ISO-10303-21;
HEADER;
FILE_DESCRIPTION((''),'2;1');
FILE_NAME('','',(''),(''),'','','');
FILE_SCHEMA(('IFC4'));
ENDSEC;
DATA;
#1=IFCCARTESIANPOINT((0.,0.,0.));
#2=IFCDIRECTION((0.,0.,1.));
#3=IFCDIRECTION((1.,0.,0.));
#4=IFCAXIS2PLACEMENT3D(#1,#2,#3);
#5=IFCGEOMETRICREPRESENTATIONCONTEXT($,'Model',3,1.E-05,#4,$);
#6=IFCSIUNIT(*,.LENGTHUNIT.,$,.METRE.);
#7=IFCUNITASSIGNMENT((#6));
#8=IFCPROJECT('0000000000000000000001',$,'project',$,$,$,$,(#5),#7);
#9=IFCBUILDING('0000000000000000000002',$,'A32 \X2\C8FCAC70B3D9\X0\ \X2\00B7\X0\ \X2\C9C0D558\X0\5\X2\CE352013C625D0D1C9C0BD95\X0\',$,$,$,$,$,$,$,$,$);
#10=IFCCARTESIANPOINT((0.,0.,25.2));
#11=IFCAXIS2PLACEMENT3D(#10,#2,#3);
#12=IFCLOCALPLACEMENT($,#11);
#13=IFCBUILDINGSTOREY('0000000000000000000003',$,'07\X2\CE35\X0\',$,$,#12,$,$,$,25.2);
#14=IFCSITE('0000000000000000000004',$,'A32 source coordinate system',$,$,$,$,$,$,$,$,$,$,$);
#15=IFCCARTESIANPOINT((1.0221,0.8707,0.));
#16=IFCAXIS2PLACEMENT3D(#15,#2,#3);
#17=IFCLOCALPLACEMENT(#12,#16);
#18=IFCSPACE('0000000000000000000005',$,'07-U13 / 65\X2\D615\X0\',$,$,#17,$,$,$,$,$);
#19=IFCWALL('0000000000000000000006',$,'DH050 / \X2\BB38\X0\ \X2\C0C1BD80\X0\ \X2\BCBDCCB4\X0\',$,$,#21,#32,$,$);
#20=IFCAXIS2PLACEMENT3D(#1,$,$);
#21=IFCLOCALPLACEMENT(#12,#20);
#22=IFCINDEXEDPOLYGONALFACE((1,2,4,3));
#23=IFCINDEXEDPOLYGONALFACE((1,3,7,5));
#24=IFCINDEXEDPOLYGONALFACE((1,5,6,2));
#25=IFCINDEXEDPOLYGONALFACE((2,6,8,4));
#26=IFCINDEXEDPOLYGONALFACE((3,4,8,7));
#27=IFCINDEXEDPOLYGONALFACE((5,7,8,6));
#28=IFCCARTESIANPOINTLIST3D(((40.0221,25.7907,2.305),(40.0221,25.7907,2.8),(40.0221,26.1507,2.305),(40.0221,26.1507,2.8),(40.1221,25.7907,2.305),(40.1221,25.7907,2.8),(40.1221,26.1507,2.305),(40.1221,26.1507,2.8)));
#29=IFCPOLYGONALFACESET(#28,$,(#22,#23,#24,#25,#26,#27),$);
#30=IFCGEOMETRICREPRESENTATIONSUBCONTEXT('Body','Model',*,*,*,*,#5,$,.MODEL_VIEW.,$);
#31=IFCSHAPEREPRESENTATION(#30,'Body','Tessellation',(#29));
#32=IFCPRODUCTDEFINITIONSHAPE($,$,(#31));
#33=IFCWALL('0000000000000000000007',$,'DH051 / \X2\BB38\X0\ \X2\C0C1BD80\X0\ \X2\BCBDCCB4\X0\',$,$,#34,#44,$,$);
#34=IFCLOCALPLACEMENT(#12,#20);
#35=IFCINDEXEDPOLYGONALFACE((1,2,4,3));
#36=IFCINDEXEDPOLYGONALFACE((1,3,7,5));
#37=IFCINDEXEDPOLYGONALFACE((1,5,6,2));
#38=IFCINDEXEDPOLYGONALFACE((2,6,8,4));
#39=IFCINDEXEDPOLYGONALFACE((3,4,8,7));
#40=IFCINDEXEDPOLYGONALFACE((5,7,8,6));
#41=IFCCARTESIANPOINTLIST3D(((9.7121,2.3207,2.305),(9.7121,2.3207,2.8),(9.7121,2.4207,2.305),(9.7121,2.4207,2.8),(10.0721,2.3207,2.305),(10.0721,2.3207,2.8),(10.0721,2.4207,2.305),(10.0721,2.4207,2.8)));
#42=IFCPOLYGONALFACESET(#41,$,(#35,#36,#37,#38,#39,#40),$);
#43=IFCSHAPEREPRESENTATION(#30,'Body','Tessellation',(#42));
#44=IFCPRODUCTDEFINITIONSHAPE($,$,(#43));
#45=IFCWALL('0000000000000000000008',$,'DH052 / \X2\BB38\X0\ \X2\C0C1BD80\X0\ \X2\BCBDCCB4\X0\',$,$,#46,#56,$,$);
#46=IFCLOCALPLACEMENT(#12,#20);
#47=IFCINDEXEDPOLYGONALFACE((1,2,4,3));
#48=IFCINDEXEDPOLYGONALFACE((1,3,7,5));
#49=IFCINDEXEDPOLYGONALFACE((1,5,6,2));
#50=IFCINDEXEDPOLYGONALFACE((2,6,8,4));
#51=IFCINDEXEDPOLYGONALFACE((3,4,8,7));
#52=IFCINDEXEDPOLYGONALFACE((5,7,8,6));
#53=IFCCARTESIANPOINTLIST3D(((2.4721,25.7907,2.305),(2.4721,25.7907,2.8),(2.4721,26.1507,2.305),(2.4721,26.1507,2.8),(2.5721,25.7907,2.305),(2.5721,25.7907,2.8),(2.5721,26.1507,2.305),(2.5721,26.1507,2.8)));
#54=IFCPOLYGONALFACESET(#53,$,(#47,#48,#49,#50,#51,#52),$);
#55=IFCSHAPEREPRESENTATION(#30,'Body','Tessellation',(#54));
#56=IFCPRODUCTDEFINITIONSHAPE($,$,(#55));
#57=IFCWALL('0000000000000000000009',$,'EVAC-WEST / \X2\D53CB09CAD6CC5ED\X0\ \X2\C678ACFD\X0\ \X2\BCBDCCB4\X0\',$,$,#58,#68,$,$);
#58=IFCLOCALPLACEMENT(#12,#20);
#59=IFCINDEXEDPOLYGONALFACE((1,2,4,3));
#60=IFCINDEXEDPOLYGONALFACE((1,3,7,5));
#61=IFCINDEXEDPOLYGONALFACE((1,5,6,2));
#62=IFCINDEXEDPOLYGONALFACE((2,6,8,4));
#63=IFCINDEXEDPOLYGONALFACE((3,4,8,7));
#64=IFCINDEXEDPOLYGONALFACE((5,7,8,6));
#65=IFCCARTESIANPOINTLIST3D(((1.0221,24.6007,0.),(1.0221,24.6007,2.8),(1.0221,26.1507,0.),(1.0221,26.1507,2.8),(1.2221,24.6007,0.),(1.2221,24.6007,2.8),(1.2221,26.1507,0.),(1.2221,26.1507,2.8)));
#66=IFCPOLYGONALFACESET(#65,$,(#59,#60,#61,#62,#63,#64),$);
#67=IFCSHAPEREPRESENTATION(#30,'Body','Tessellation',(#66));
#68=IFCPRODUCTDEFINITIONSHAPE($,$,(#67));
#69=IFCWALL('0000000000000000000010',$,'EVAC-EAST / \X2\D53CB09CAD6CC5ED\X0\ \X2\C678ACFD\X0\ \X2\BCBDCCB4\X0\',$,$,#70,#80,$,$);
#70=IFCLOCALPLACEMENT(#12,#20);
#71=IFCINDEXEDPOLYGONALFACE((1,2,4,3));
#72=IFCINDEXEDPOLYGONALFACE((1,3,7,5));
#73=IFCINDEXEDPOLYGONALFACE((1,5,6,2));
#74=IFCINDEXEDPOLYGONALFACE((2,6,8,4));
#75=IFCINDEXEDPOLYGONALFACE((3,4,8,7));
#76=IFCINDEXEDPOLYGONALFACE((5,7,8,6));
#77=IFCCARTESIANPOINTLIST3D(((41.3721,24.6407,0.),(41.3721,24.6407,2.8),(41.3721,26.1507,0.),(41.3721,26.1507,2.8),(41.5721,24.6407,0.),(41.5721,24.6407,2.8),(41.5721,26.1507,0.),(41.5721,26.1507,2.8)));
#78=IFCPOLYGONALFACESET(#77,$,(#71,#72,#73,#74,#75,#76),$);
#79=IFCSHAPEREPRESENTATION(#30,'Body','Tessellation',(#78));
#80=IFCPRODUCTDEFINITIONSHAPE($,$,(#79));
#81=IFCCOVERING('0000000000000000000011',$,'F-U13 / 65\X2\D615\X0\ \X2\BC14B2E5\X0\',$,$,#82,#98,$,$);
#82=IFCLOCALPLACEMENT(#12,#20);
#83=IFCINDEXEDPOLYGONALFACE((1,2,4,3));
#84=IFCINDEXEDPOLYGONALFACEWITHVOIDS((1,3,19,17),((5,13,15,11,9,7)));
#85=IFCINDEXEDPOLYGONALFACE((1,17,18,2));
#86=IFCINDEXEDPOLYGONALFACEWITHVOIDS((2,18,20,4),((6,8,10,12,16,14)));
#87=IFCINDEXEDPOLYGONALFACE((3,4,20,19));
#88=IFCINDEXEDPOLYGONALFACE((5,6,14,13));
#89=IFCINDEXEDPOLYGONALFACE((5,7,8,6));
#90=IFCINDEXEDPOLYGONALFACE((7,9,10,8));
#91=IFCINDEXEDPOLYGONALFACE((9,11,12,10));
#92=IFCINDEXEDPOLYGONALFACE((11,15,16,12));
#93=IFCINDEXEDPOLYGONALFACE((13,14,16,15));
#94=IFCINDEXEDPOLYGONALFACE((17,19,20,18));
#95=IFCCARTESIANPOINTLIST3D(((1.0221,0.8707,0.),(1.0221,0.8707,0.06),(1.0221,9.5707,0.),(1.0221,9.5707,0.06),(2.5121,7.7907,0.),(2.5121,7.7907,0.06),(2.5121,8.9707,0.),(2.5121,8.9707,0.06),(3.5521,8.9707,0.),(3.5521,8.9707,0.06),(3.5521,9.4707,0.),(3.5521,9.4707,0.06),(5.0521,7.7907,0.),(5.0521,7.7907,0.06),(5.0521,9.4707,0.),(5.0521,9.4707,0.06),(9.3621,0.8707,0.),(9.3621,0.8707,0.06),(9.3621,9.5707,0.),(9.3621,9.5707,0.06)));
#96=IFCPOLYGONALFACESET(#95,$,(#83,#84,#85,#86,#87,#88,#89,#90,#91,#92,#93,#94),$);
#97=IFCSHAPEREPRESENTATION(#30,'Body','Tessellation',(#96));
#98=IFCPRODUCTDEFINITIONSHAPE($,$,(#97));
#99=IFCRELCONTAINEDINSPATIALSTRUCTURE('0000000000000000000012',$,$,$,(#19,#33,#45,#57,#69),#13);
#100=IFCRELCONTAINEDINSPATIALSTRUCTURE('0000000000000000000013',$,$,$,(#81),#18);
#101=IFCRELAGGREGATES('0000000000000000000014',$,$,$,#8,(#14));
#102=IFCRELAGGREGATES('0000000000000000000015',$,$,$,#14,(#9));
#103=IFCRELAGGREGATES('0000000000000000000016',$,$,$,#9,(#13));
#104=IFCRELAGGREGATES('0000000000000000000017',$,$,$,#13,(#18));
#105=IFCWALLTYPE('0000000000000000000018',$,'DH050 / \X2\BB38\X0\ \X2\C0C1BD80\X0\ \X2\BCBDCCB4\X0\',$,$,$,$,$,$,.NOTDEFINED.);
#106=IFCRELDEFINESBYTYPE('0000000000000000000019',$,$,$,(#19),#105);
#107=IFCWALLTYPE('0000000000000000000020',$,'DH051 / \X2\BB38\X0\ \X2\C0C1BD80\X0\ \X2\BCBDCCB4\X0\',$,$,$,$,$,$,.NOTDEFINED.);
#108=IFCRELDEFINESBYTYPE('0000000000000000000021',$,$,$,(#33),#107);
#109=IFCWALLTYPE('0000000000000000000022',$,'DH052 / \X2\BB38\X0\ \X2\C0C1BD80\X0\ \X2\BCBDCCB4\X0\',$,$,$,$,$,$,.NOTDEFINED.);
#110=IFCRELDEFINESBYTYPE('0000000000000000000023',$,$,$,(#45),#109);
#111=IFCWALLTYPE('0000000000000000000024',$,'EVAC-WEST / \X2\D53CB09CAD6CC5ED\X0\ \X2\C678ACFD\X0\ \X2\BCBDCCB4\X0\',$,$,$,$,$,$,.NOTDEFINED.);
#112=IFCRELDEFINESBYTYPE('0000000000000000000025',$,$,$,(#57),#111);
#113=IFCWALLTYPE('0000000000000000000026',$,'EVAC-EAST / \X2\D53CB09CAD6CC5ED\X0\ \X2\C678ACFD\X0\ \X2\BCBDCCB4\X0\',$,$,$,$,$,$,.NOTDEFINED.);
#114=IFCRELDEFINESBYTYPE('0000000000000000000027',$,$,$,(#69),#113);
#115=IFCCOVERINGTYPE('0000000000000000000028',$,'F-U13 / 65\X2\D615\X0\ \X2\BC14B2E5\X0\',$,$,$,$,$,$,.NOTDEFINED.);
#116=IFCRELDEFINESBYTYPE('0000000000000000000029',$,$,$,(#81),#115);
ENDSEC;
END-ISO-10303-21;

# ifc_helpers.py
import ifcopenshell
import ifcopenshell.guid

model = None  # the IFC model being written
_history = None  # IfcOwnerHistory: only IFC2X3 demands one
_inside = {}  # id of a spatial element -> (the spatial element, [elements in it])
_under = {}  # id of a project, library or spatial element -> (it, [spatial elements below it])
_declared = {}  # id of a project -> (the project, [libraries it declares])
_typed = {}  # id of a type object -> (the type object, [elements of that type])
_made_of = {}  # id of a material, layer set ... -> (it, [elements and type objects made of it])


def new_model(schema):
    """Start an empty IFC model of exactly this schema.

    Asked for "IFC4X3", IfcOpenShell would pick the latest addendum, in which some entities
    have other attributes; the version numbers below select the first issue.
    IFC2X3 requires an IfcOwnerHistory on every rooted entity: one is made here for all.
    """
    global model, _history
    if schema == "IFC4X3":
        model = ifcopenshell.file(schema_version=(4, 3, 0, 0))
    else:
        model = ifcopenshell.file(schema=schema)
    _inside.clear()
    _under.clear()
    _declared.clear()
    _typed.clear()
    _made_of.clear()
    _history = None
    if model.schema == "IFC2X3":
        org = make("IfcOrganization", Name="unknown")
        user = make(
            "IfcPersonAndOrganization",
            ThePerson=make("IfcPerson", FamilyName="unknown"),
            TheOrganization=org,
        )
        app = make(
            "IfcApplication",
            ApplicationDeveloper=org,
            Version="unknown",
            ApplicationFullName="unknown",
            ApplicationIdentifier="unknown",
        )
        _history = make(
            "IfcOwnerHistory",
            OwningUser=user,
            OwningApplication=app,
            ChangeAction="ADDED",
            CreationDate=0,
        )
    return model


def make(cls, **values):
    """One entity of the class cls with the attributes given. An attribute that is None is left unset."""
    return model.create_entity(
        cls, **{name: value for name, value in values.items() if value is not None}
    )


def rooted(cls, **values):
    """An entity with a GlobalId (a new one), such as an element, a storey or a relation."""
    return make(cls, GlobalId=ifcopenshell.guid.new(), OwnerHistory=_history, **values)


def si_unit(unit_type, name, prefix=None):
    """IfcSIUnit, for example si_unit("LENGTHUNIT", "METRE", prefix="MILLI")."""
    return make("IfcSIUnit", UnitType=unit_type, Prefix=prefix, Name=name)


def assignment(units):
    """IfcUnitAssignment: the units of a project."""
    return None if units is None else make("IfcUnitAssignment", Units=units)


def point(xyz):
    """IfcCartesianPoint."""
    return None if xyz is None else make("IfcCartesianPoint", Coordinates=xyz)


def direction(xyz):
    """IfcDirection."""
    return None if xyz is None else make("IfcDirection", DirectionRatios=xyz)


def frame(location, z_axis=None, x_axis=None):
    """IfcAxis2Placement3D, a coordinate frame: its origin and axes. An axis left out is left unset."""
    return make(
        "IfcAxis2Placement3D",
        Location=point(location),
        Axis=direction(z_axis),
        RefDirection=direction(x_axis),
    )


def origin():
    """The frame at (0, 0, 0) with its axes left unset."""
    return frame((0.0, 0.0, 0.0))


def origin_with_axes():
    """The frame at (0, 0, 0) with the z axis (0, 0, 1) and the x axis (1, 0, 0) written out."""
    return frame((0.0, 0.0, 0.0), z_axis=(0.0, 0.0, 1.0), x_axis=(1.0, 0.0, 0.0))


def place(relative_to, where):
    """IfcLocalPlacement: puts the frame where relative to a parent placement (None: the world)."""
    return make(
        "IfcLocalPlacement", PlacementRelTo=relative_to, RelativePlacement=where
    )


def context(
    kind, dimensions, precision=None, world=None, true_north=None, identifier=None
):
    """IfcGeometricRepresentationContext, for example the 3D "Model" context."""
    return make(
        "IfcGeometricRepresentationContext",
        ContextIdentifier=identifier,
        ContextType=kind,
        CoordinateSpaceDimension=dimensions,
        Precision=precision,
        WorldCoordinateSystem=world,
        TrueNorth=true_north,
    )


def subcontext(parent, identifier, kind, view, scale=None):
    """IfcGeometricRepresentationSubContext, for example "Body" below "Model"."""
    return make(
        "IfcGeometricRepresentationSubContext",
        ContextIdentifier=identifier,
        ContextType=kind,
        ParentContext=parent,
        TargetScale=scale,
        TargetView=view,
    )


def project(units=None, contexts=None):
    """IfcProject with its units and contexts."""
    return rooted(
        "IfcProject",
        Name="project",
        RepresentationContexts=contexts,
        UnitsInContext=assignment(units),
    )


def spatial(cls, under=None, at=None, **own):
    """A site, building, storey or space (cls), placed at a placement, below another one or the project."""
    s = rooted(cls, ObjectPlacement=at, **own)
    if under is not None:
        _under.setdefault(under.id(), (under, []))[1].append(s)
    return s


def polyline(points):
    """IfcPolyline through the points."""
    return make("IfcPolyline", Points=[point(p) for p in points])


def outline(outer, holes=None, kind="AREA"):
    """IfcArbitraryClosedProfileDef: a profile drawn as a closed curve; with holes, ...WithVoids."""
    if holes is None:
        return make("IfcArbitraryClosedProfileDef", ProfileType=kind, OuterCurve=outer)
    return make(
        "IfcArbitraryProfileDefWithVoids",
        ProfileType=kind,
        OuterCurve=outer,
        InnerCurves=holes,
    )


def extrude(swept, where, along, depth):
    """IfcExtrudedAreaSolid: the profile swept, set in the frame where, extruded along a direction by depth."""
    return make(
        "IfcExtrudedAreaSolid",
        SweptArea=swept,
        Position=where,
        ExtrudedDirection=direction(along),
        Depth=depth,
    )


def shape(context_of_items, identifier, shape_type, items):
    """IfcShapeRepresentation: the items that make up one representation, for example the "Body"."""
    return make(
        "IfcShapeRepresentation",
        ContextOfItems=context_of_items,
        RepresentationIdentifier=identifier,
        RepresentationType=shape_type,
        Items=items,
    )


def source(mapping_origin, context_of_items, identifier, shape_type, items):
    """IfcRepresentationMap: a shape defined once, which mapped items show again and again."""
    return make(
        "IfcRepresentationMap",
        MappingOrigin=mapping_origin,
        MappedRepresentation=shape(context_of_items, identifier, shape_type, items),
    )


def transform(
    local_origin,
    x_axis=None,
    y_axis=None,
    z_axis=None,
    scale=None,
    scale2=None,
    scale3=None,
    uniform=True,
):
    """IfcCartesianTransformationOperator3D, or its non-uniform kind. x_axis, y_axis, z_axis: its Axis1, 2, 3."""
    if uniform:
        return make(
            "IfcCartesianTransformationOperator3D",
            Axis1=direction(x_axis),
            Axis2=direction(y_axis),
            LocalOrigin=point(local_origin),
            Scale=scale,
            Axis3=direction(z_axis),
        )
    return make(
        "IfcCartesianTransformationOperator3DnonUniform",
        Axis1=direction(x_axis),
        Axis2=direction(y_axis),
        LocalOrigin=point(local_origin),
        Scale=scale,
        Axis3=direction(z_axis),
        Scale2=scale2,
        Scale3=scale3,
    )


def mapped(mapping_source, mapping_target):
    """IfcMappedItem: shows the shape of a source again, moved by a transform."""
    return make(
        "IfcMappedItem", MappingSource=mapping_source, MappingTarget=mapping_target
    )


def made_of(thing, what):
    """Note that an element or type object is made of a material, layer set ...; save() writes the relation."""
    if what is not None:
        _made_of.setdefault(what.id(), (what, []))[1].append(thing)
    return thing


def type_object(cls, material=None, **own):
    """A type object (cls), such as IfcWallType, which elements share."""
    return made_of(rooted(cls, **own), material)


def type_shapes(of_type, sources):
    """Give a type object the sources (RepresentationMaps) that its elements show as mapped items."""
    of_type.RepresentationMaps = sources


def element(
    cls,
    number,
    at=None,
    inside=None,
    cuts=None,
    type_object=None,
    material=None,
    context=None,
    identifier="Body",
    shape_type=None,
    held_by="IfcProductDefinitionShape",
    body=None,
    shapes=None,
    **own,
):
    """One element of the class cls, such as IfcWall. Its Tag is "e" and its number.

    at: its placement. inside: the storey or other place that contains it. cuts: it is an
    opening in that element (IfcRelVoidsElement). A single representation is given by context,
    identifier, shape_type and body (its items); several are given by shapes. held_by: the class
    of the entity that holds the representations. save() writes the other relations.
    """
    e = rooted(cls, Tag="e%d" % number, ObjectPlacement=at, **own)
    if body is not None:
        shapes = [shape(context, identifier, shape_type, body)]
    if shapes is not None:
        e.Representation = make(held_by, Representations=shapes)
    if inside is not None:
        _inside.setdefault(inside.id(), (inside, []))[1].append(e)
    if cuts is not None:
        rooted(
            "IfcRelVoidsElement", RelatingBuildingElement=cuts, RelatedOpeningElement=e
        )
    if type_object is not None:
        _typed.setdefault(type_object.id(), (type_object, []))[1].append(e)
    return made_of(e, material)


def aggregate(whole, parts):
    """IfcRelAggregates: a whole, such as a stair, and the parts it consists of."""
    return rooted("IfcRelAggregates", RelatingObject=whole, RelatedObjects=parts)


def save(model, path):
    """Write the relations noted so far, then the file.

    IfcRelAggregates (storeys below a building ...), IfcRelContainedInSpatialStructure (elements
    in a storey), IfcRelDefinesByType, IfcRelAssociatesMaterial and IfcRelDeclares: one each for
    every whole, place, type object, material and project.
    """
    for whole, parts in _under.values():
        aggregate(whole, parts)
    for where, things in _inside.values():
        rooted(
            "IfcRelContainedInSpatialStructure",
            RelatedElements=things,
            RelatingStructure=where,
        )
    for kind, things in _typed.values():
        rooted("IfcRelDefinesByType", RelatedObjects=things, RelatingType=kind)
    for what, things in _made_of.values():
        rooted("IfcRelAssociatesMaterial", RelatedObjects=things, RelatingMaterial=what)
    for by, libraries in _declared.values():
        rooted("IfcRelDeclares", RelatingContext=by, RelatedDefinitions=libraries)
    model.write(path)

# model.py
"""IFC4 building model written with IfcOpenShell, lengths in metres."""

from ifc_helpers import new_model, si_unit, frame, origin, origin_with_axes, place, context, subcontext, project, spatial, polyline, outline, extrude, source, transform, mapped, type_object, type_shapes, element, save


model = new_model("IFC4")

# Units and contexts
model_context = context("Model", 3, precision=1e-05, world=origin_with_axes())
body_context = subcontext(model_context, "Body", "Model", "MODEL_VIEW")
ifc_project = project(units=[si_unit("LENGTHUNIT", "METRE")], contexts=[model_context])

# Site, building, storey
site = spatial("IfcSite", under=ifc_project, Name="A32 source coordinate system")
building = spatial("IfcBuilding", under=site, Name="A32 주거동 · 지하5층–옥탑지붕")
storey_placement = place(None, frame((0.0, 0.0, 25.2), z_axis=(0.0, 0.0, 1.0), x_axis=(1.0, 0.0, 0.0)))
storey = spatial("IfcBuildingStorey", under=building, at=storey_placement, Name="07층", Elevation=25.2)

# Walls
wall_type_1 = type_object("IfcWallType", Name="DH050 / 문 상부 벽체", PredefinedType="NOTDEFINED")
shared_shape_1 = source(origin(), body_context, "Body", "SweptSolid", [
    extrude(outline(polyline([(40.0221, 25.7907), (40.0221, 26.1507), (40.1221, 26.1507), (40.1221, 25.7907), (40.0221, 25.7907)])), frame((0.0, 0.0, 2.305)), (0.0, 0.0, 1.0), 0.495),
])
type_shapes(wall_type_1, [shared_shape_1])
wall_1_placement = place(storey_placement, origin_with_axes())
element("IfcWall", 1, at=wall_1_placement, inside=storey, type_object=wall_type_1, Name="DH050 / 문 상부 벽체", context=body_context, shape_type="MappedRepresentation", body=[
    mapped(shared_shape_1, transform((0.0, 0.0, 0.0), scale=1.0)),
])
wall_type_2 = type_object("IfcWallType", Name="DH051 / 문 상부 벽체", PredefinedType="NOTDEFINED")
shared_shape_2 = source(origin(), body_context, "Body", "SweptSolid", [
    extrude(outline(polyline([(10.0721, 2.3207), (9.7121, 2.3207), (9.7121, 2.4207), (10.0721, 2.4207), (10.0721, 2.3207)])), frame((0.0, 0.0, 2.305)), (0.0, 0.0, 1.0), 0.495),
])
type_shapes(wall_type_2, [shared_shape_2])
wall_2_placement = place(storey_placement, origin_with_axes())
element("IfcWall", 2, at=wall_2_placement, inside=storey, type_object=wall_type_2, Name="DH051 / 문 상부 벽체", context=body_context, shape_type="MappedRepresentation", body=[
    mapped(shared_shape_2, transform((0.0, 0.0, 0.0), scale=1.0)),
])
wall_type_3 = type_object("IfcWallType", Name="DH052 / 문 상부 벽체", PredefinedType="NOTDEFINED")
shared_shape_3 = source(origin(), body_context, "Body", "SweptSolid", [
    extrude(outline(polyline([(2.5721, 25.7907), (2.4721, 25.7907), (2.4721, 26.1507), (2.5721, 26.1507), (2.5721, 25.7907)])), frame((0.0, 0.0, 2.305)), (0.0, 0.0, 1.0), 0.495),
])
type_shapes(wall_type_3, [shared_shape_3])
wall_3_placement = place(storey_placement, origin_with_axes())
element("IfcWall", 3, at=wall_3_placement, inside=storey, type_object=wall_type_3, Name="DH052 / 문 상부 벽체", context=body_context, shape_type="MappedRepresentation", body=[
    mapped(shared_shape_3, transform((0.0, 0.0, 0.0), scale=1.0)),
])
wall_type_4 = type_object("IfcWallType", Name="EVAC-WEST / 피난구역 외곽 벽체", PredefinedType="NOTDEFINED")
shared_shape_4 = source(origin(), body_context, "Body", "SweptSolid", [
    extrude(outline(polyline([(1.2221, 24.6007), (1.0221, 24.6007), (1.0221, 26.1507), (1.2221, 26.1507), (1.2221, 24.6007)])), origin(), (0.0, 0.0, 1.0), 2.8),
])
type_shapes(wall_type_4, [shared_shape_4])
wall_4_placement = place(storey_placement, origin_with_axes())
element("IfcWall", 4, at=wall_4_placement, inside=storey, type_object=wall_type_4, Name="EVAC-WEST / 피난구역 외곽 벽체", context=body_context, shape_type="MappedRepresentation", body=[
    mapped(shared_shape_4, transform((0.0, 0.0, 0.0), scale=1.0)),
])
wall_type_5 = type_object("IfcWallType", Name="EVAC-EAST / 피난구역 외곽 벽체", PredefinedType="NOTDEFINED")
shared_shape_5 = source(origin(), body_context, "Body", "SweptSolid", [
    extrude(outline(polyline([(41.5721, 26.1507), (41.5721, 24.6407), (41.3721, 24.6407), (41.3721, 26.1507), (41.5721, 26.1507)])), origin(), (0.0, 0.0, 1.0), 2.8),
])
type_shapes(wall_type_5, [shared_shape_5])
wall_5_placement = place(storey_placement, origin_with_axes())
element("IfcWall", 5, at=wall_5_placement, inside=storey, type_object=wall_type_5, Name="EVAC-EAST / 피난구역 외곽 벽체", context=body_context, shape_type="MappedRepresentation", body=[
    mapped(shared_shape_5, transform((0.0, 0.0, 0.0), scale=1.0)),
])

# Shared definitions
space_placement = place(storey_placement, frame((1.0221, 0.8707, 0.0), z_axis=(0.0, 0.0, 1.0), x_axis=(1.0, 0.0, 0.0)))
space = spatial("IfcSpace", under=storey, at=space_placement, Name="07-U13 / 65형")

# Covering
covering_type_1 = type_object("IfcCoveringType", Name="F-U13 / 65형 바닥", PredefinedType="NOTDEFINED")
shared_shape_6 = source(origin(), body_context, "Body", "SweptSolid", [
    extrude(outline(polyline([(0.0, 0.0), (0.0, 8.7), (8.34, 8.7), (8.34, 0.0), (0.0, 0.0)]), holes=[polyline([(2.53, 8.1), (1.49, 8.1), (1.49, 6.92), (4.03, 6.92), (4.03, 8.6), (2.53, 8.6), (2.53, 8.1)])]), origin(), (0.0, 0.0, 1.0), 0.06),
])
type_shapes(covering_type_1, [shared_shape_6])
covering_1_placement = place(space_placement, origin_with_axes())
element("IfcCovering", 6, at=covering_1_placement, inside=space, type_object=covering_type_1, Name="F-U13 / 65형 바닥", context=body_context, shape_type="MappedRepresentation", body=[
    mapped(shared_shape_6, transform((0.0, 0.0, 0.0), scale=1.0)),
])

save(model, "model.ifc")
